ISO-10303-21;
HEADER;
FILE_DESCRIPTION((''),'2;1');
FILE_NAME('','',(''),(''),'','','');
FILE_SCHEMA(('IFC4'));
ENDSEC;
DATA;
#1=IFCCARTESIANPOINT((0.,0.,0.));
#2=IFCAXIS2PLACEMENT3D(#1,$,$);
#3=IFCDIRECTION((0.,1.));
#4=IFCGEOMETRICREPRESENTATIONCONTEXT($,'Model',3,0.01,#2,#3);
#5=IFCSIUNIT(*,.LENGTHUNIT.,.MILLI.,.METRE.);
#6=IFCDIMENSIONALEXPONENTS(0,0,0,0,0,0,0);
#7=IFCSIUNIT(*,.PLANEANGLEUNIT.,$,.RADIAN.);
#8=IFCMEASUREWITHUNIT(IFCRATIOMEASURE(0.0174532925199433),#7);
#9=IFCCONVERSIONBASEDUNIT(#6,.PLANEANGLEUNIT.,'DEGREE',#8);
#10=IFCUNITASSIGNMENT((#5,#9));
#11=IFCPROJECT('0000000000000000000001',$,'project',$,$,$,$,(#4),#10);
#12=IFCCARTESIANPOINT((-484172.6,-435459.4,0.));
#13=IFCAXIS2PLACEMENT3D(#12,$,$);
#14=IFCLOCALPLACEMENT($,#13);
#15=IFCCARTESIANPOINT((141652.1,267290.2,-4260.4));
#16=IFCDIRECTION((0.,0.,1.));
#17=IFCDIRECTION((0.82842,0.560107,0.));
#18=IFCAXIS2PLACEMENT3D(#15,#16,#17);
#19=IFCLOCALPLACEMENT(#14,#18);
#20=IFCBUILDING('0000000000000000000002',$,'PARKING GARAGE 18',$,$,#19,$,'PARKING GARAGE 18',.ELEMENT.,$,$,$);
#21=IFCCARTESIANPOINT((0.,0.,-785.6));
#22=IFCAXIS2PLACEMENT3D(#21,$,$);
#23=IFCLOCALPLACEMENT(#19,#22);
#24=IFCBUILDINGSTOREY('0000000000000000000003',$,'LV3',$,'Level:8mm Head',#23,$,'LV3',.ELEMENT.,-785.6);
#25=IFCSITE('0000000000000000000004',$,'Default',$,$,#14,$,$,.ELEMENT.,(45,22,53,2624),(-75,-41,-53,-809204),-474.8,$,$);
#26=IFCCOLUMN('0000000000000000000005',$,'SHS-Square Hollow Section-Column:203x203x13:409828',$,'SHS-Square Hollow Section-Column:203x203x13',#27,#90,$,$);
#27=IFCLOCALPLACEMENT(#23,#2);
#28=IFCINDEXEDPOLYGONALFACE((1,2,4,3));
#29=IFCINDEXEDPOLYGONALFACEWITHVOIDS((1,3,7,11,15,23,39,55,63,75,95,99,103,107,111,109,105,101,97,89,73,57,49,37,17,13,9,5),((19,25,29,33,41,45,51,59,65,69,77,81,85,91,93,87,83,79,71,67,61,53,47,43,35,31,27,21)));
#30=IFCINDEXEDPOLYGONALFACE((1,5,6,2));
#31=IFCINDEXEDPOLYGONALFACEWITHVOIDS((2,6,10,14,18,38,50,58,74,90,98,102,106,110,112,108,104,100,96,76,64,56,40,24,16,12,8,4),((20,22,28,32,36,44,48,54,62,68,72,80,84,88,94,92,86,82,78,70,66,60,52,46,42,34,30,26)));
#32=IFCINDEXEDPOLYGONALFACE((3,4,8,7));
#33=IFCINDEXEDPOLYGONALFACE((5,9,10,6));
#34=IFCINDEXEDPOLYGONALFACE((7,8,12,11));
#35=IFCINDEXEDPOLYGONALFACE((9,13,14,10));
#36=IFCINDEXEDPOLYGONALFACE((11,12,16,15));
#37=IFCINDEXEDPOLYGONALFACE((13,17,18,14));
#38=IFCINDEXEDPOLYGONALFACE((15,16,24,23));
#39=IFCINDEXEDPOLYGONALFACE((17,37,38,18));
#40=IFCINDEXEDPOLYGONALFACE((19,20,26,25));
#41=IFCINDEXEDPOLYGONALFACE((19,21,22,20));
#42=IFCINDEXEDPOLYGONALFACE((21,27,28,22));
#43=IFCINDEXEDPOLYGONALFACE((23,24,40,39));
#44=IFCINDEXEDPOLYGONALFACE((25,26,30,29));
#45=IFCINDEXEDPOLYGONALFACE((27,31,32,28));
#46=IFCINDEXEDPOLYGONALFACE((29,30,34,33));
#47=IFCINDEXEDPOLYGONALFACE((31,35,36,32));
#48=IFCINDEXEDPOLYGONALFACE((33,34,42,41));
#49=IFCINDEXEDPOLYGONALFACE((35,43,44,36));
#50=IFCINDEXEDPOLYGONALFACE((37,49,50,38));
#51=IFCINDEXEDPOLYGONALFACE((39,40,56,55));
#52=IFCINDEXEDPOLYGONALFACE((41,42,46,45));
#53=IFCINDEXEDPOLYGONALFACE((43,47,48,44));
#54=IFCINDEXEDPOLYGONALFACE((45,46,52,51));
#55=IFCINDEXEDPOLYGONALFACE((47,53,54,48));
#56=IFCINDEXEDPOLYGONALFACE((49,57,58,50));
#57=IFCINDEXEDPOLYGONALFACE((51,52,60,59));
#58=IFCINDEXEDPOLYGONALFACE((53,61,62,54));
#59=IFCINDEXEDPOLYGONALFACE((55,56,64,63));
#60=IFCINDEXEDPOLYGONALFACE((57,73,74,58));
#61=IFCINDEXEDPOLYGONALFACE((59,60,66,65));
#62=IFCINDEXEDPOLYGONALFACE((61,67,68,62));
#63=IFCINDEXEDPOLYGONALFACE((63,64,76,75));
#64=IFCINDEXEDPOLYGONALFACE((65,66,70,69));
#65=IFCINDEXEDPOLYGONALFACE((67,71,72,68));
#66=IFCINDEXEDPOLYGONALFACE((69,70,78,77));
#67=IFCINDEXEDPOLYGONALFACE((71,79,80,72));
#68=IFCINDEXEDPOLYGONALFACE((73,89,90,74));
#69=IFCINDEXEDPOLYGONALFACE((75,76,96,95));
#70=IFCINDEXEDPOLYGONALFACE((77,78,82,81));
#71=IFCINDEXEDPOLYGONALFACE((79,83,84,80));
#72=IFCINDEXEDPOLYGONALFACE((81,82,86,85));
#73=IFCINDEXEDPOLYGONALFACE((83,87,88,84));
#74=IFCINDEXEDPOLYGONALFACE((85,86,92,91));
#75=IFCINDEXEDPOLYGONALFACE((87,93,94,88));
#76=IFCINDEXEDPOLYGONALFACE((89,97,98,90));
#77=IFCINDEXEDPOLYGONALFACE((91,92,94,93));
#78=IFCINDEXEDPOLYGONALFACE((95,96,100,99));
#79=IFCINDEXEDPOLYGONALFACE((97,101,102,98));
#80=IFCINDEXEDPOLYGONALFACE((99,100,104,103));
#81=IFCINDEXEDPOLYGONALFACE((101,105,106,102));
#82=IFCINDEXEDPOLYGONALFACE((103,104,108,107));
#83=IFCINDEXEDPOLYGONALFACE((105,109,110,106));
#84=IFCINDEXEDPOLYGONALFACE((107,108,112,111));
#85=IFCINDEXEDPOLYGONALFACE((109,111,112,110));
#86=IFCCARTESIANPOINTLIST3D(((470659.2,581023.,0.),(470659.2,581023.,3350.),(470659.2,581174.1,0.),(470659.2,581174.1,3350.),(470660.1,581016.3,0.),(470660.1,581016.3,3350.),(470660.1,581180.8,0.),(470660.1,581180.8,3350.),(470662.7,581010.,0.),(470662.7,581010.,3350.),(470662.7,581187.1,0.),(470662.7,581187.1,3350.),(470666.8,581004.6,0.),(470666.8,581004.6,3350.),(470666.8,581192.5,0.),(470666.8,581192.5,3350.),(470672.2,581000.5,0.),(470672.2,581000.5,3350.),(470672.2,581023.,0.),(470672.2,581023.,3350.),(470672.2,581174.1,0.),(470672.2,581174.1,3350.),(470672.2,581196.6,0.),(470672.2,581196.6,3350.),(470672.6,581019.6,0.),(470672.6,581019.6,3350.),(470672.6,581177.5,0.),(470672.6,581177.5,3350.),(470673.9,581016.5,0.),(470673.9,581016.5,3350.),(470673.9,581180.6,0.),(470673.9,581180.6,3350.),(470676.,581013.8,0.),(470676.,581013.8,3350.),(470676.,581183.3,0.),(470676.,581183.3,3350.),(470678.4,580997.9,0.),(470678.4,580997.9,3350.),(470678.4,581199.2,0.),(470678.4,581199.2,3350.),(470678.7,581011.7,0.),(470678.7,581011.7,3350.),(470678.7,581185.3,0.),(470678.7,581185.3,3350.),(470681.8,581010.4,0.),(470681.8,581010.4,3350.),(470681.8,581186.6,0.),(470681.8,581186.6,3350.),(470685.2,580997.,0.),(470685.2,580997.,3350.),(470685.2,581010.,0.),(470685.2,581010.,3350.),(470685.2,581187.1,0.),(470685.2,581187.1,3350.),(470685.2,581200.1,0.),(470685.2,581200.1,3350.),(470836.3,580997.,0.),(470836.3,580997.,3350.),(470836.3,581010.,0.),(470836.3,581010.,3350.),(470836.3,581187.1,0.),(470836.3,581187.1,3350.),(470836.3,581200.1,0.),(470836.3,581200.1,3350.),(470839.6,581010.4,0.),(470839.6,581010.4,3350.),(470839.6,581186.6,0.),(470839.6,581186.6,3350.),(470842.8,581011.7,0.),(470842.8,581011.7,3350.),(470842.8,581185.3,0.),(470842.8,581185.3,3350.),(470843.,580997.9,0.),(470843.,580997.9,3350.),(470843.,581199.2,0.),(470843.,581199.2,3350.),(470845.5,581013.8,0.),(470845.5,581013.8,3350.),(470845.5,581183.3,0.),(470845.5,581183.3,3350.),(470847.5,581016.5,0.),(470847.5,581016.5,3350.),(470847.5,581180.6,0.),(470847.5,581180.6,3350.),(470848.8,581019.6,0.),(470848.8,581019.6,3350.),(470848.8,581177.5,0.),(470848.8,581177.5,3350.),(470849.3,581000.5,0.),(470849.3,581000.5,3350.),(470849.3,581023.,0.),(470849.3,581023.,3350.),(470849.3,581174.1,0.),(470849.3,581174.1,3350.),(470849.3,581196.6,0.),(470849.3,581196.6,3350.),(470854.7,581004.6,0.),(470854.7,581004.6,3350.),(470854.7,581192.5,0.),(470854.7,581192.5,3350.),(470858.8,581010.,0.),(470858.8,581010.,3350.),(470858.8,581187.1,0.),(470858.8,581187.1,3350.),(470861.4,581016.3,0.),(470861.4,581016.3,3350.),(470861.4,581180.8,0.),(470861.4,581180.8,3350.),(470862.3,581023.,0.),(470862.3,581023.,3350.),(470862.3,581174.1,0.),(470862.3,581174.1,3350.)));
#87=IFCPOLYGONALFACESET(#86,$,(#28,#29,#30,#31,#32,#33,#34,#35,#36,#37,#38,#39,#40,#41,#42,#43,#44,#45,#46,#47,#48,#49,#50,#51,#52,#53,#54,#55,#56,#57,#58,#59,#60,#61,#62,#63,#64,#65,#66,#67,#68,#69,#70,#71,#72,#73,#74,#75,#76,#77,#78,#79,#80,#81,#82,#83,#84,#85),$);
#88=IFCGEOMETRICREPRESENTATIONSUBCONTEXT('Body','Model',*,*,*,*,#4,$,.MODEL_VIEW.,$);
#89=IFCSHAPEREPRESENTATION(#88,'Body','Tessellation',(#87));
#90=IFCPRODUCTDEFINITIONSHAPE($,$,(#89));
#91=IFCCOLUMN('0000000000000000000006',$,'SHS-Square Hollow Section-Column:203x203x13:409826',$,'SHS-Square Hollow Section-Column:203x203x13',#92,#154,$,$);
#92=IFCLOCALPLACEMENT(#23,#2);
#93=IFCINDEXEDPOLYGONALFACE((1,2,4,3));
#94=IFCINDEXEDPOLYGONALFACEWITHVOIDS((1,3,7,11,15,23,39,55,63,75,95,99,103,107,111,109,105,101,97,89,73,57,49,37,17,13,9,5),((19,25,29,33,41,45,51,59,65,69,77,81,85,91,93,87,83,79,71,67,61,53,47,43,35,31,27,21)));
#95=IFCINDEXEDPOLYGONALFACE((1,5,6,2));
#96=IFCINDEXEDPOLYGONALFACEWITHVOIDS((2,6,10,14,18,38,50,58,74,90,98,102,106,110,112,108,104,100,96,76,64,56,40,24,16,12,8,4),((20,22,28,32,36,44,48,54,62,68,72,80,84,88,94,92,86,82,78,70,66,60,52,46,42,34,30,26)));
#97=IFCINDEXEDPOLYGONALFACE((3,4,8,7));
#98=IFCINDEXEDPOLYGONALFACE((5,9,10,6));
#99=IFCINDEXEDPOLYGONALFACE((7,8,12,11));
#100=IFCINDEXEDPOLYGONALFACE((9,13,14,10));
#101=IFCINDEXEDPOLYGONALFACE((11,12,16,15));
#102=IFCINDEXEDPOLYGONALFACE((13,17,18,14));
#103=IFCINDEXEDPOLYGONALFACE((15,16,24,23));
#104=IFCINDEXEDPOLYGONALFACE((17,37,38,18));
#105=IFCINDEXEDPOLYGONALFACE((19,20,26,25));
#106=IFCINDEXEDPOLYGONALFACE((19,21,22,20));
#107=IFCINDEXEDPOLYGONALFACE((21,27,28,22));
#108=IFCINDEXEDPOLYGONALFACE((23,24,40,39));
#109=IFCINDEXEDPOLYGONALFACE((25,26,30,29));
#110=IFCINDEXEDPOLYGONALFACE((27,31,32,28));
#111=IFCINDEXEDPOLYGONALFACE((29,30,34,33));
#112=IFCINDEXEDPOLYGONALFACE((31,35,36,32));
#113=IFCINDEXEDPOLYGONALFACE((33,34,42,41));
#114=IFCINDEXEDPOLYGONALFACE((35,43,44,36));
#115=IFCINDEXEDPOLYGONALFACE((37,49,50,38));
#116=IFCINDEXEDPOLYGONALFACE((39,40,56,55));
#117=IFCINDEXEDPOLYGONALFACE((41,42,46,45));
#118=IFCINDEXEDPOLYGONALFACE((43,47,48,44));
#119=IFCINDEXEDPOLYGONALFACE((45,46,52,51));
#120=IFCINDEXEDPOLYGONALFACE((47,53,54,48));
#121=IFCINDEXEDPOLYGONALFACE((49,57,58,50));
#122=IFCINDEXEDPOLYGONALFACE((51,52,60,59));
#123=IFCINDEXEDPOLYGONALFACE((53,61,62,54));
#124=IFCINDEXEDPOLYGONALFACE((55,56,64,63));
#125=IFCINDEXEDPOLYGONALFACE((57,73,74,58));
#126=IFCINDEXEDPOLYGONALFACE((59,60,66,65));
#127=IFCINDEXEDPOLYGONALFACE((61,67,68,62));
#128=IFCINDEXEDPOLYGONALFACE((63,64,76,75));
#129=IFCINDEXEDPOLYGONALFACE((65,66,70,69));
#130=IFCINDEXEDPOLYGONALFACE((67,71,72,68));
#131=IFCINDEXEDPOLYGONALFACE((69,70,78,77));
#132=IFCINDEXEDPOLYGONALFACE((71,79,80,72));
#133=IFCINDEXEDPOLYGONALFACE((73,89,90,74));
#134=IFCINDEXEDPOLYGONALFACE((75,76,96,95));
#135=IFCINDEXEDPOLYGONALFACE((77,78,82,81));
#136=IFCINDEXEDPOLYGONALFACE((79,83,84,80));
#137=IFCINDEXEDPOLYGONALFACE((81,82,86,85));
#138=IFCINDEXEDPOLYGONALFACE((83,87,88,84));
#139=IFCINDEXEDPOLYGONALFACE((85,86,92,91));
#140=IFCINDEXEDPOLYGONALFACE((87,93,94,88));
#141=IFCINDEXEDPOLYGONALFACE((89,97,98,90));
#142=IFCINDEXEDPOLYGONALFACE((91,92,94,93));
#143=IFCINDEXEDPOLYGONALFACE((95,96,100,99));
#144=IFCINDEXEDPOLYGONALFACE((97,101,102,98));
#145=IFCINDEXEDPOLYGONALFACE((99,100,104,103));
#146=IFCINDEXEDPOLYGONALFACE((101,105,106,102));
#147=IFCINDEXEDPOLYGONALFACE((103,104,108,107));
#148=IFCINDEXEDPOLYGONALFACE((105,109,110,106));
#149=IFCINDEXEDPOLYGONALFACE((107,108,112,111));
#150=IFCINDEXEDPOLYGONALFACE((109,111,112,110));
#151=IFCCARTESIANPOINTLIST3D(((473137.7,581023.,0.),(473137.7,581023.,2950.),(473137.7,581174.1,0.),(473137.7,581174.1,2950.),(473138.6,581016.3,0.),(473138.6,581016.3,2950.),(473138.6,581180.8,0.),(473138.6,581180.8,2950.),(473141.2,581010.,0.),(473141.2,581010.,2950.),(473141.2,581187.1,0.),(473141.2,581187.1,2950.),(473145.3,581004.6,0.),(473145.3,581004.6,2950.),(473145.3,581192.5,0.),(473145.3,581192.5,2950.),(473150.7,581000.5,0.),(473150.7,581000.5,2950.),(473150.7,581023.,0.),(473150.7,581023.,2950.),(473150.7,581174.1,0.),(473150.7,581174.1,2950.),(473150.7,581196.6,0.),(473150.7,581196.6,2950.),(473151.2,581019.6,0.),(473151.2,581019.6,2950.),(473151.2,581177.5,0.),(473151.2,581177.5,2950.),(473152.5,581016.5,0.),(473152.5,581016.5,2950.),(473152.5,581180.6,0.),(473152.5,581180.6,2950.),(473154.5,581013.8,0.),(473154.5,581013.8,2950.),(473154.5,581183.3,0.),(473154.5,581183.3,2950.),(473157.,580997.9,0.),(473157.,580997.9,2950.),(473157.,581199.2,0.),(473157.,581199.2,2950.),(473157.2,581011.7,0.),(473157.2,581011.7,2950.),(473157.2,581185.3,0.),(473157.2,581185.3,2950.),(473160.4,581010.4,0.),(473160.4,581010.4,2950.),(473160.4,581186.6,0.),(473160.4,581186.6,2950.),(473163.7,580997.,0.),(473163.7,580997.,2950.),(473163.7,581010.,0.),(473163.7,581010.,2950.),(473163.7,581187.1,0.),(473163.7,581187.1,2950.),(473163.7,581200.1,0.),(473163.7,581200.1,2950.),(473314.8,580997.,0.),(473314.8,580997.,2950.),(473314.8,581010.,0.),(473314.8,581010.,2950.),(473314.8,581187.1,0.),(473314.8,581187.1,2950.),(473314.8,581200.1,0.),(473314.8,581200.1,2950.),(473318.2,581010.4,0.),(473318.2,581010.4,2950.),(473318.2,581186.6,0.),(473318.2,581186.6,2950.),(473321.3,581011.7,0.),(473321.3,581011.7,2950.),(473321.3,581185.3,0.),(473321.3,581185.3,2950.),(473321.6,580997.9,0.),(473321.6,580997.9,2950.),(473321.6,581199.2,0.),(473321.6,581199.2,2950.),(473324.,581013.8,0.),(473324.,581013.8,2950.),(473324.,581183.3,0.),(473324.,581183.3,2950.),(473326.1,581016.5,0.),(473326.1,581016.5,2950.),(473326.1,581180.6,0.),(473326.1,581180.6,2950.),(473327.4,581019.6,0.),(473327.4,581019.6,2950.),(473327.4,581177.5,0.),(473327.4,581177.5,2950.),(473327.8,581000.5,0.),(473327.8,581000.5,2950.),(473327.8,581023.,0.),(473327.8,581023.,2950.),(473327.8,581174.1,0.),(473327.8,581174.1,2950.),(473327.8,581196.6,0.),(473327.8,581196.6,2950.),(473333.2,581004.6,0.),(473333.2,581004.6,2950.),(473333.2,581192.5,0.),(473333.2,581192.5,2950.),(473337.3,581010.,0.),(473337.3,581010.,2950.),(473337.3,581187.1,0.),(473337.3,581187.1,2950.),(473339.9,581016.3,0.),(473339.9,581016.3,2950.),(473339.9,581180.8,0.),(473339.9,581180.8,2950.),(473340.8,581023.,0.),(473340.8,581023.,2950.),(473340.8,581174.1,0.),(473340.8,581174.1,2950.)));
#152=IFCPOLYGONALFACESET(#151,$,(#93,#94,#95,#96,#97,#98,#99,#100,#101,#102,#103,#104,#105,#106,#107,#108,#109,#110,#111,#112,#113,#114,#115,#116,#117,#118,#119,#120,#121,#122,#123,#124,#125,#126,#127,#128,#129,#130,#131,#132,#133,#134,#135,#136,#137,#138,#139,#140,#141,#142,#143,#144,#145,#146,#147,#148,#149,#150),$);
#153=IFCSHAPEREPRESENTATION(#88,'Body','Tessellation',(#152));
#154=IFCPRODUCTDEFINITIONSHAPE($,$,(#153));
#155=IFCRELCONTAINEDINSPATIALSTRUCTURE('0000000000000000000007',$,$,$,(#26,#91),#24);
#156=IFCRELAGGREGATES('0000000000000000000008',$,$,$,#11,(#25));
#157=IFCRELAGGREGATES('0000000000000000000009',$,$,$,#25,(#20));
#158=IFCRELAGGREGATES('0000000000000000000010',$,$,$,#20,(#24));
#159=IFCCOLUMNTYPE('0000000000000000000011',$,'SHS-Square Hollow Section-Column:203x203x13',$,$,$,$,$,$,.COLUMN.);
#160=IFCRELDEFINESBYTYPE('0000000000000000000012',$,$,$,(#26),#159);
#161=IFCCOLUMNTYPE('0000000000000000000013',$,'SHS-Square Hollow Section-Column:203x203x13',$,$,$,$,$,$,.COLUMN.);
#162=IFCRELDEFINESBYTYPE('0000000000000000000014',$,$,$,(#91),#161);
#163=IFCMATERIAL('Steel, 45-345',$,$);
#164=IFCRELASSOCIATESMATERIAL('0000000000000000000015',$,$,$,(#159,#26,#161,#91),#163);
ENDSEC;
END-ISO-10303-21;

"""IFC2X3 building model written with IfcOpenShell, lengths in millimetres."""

from ifc_helpers import new_model, entity, si_unit, converted_unit, direction, frame, frame_2d, origin, place, context, subcontext, project, spatial, polyline, circle_curve, parameter, trimmed, segment, composite_curve, outline, extrude, source, transform, mapped, material, type_object, type_shapes, element, save


model = new_model("IFC2X3")

# Units and contexts
model_context = context("Model", 3, precision=0.01, world=origin(), true_north=direction((0.0, 1.0)))
body_context = subcontext(model_context, "Body", "Model", "MODEL_VIEW")
ifc_project = project(units=[si_unit("LENGTHUNIT", "METRE", prefix="MILLI"), converted_unit("PLANEANGLEUNIT", "DEGREE", entity("IfcRatioMeasure", 0.0174532925199433), si_unit("PLANEANGLEUNIT", "RADIAN"), dimensions=[0, 0, 0, 0, 0, 0, 0])], contexts=[model_context])

# Site, building, storey
site_placement = place(None, frame((-484172.6, -435459.4, 0.0)))
site = spatial("IfcSite", under=ifc_project, at=site_placement, Name="Default", CompositionType="ELEMENT", RefLatitude=(45, 22, 53, 2624), RefLongitude=(-75, -41, -53, -809204), RefElevation=-474.8)
building_placement = place(site_placement, frame((141652.1, 267290.2, -4260.4), z_axis=(0.0, 0.0, 1.0), x_axis=(0.82842, 0.560107, 0.0)))
building = spatial("IfcBuilding", under=site, at=building_placement, Name="PARKING GARAGE 18", LongName="PARKING GARAGE 18", CompositionType="ELEMENT")
storey_placement = place(building_placement, frame((0.0, 0.0, -785.6)))
storey = spatial("IfcBuildingStorey", under=building, at=storey_placement, Name="LV3", ObjectType="Level:8mm Head", LongName="LV3", CompositionType="ELEMENT", Elevation=-785.6)

# Columns
ifc_material_1 = material(Name="Steel, 45-345")
column_type_1 = type_object("IfcColumnType", Name="SHS-Square Hollow Section-Column:203x203x13", PredefinedType="COLUMN", material=ifc_material_1)
shared_shape_1 = source(origin(), body_context, "Body", "SweptSolid", [
    extrude(outline(composite_curve([segment(polyline([(-75.6, -101.5), (75.6, -101.5)]), True, "CONTINUOUS"), segment(trimmed(circle_curve(frame_2d((75.6, -75.6), x_axis=(-1.0, 0.0)), 26.0), [parameter(90.0)], [parameter(180.0)], True, "PARAMETER"), True, "CONTINUOUS"), segment(polyline([(101.5, -75.6), (101.5, 75.6)]), True, "CONTINUOUS"), segment(trimmed(circle_curve(frame_2d((75.5, 75.6), x_axis=(-1.0, 0.0)), 26.0), [parameter(180.0)], [parameter(270.0)], True, "PARAMETER"), True, "CONTINUOUS"), segment(polyline([(75.5, 101.6), (-75.5, 101.6)]), True, "CONTINUOUS"), segment(trimmed(circle_curve(frame_2d((-75.5, 75.5), x_axis=(-1.0, 0.0)), 26.0), [parameter(270.0)], [parameter(360.0)], True, "PARAMETER"), True, "CONTINUOUS"), segment(polyline([(-101.5, 75.5), (-101.5, -75.6)]), True, "CONTINUOUS"), segment(trimmed(circle_curve(frame_2d((-75.6, -75.6), x_axis=(-1.0, 0.0)), 26.0), [parameter(360.0)], [parameter(90.0)], True, "PARAMETER"), True, "CONTINUOUS")], self_intersect=False), holes=[composite_curve([segment(trimmed(circle_curve(frame_2d((-75.6, -75.6), x_axis=(-1.0, 0.0)), 13.0), [parameter(0.0)], [parameter(90.0)], True, "PARAMETER"), False, "CONTINUOUS"), segment(polyline([(-88.5, -75.6), (-88.5, 75.6)]), True, "CONTINUOUS"), segment(trimmed(circle_curve(frame_2d((-75.6, 75.6), x_axis=(-1.0, 0.0)), 13.0), [parameter(270.0)], [parameter(0.0)], True, "PARAMETER"), False, "CONTINUOUS"), segment(polyline([(-75.6, 88.6), (75.5, 88.6)]), True, "CONTINUOUS"), segment(trimmed(circle_curve(frame_2d((75.5, 75.5), x_axis=(-1.0, 0.0)), 13.0), [parameter(180.0)], [parameter(270.0)], True, "PARAMETER"), False, "CONTINUOUS"), segment(polyline([(88.6, 75.5), (88.6, -75.5)]), True, "CONTINUOUS"), segment(trimmed(circle_curve(frame_2d((75.6, -75.5), x_axis=(-1.0, 0.0)), 13.0), [parameter(90.0)], [parameter(180.0)], True, "PARAMETER"), False, "CONTINUOUS"), segment(polyline([(75.6, -88.5), (-75.6, -88.5)]), True, "CONTINUOUS")], self_intersect=False)]), frame((0.0, 0.0, -785.6), z_axis=(0.0, 0.0, 1.0), x_axis=(-1.0, 0.0, 0.0)), (0.0, 0.0, 1.0), 3350.0),
])
type_shapes(column_type_1, [shared_shape_1])
column_1_placement = place(storey_placement, frame((470760.7, 581098.5, 785.6)))
element("IfcColumn", 1, at=column_1_placement, inside=storey, type_object=column_type_1, material=ifc_material_1, Name="SHS-Square Hollow Section-Column:203x203x13:409828", ObjectType="SHS-Square Hollow Section-Column:203x203x13", context=body_context, shape_type="MappedRepresentation", body=[
    mapped(shared_shape_1, transform((0.0, 0.0, 0.0), scale=1.0)),
])
column_type_2 = type_object("IfcColumnType", Name="SHS-Square Hollow Section-Column:203x203x13", PredefinedType="COLUMN", material=ifc_material_1)
shared_shape_2 = source(origin(), body_context, "Body", "SweptSolid", [
    extrude(outline(composite_curve([segment(polyline([(-75.6, -101.5), (75.6, -101.5)]), True, "CONTINUOUS"), segment(trimmed(circle_curve(frame_2d((75.6, -75.6), x_axis=(-1.0, 0.0)), 26.0), [parameter(90.0)], [parameter(180.0)], True, "PARAMETER"), True, "CONTINUOUS"), segment(polyline([(101.5, -75.6), (101.5, 75.6)]), True, "CONTINUOUS"), segment(trimmed(circle_curve(frame_2d((75.5, 75.6), x_axis=(-1.0, 0.0)), 26.0), [parameter(180.0)], [parameter(270.0)], True, "PARAMETER"), True, "CONTINUOUS"), segment(polyline([(75.5, 101.6), (-75.5, 101.6)]), True, "CONTINUOUS"), segment(trimmed(circle_curve(frame_2d((-75.5, 75.5), x_axis=(-1.0, 0.0)), 26.0), [parameter(270.0)], [parameter(360.0)], True, "PARAMETER"), True, "CONTINUOUS"), segment(polyline([(-101.5, 75.5), (-101.5, -75.6)]), True, "CONTINUOUS"), segment(trimmed(circle_curve(frame_2d((-75.6, -75.6), x_axis=(-1.0, 0.0)), 26.0), [parameter(360.0)], [parameter(90.0)], True, "PARAMETER"), True, "CONTINUOUS")], self_intersect=False), holes=[composite_curve([segment(trimmed(circle_curve(frame_2d((-75.6, -75.6), x_axis=(-1.0, 0.0)), 13.0), [parameter(0.0)], [parameter(90.0)], True, "PARAMETER"), False, "CONTINUOUS"), segment(polyline([(-88.5, -75.6), (-88.5, 75.6)]), True, "CONTINUOUS"), segment(trimmed(circle_curve(frame_2d((-75.6, 75.6), x_axis=(-1.0, 0.0)), 13.0), [parameter(270.0)], [parameter(0.0)], True, "PARAMETER"), False, "CONTINUOUS"), segment(polyline([(-75.6, 88.6), (75.5, 88.6)]), True, "CONTINUOUS"), segment(trimmed(circle_curve(frame_2d((75.5, 75.5), x_axis=(-1.0, 0.0)), 13.0), [parameter(180.0)], [parameter(270.0)], True, "PARAMETER"), False, "CONTINUOUS"), segment(polyline([(88.6, 75.5), (88.6, -75.5)]), True, "CONTINUOUS"), segment(trimmed(circle_curve(frame_2d((75.6, -75.5), x_axis=(-1.0, 0.0)), 13.0), [parameter(90.0)], [parameter(180.0)], True, "PARAMETER"), False, "CONTINUOUS"), segment(polyline([(75.6, -88.5), (-75.6, -88.5)]), True, "CONTINUOUS")], self_intersect=False)]), frame((0.0, 0.0, -785.6), z_axis=(0.0, 0.0, 1.0), x_axis=(-1.0, 0.0, 0.0)), (0.0, 0.0, 1.0), 2950.0),
])
type_shapes(column_type_2, [shared_shape_2])
column_2_placement = place(storey_placement, frame((473239.3, 581098.5, 785.6)))
element("IfcColumn", 2, at=column_2_placement, inside=storey, type_object=column_type_2, material=ifc_material_1, Name="SHS-Square Hollow Section-Column:203x203x13:409826", ObjectType="SHS-Square Hollow Section-Column:203x203x13", context=body_context, shape_type="MappedRepresentation", body=[
    mapped(shared_shape_2, transform((0.0, 0.0, 0.0), scale=1.0)),
])

save(model, "model.ifc")
